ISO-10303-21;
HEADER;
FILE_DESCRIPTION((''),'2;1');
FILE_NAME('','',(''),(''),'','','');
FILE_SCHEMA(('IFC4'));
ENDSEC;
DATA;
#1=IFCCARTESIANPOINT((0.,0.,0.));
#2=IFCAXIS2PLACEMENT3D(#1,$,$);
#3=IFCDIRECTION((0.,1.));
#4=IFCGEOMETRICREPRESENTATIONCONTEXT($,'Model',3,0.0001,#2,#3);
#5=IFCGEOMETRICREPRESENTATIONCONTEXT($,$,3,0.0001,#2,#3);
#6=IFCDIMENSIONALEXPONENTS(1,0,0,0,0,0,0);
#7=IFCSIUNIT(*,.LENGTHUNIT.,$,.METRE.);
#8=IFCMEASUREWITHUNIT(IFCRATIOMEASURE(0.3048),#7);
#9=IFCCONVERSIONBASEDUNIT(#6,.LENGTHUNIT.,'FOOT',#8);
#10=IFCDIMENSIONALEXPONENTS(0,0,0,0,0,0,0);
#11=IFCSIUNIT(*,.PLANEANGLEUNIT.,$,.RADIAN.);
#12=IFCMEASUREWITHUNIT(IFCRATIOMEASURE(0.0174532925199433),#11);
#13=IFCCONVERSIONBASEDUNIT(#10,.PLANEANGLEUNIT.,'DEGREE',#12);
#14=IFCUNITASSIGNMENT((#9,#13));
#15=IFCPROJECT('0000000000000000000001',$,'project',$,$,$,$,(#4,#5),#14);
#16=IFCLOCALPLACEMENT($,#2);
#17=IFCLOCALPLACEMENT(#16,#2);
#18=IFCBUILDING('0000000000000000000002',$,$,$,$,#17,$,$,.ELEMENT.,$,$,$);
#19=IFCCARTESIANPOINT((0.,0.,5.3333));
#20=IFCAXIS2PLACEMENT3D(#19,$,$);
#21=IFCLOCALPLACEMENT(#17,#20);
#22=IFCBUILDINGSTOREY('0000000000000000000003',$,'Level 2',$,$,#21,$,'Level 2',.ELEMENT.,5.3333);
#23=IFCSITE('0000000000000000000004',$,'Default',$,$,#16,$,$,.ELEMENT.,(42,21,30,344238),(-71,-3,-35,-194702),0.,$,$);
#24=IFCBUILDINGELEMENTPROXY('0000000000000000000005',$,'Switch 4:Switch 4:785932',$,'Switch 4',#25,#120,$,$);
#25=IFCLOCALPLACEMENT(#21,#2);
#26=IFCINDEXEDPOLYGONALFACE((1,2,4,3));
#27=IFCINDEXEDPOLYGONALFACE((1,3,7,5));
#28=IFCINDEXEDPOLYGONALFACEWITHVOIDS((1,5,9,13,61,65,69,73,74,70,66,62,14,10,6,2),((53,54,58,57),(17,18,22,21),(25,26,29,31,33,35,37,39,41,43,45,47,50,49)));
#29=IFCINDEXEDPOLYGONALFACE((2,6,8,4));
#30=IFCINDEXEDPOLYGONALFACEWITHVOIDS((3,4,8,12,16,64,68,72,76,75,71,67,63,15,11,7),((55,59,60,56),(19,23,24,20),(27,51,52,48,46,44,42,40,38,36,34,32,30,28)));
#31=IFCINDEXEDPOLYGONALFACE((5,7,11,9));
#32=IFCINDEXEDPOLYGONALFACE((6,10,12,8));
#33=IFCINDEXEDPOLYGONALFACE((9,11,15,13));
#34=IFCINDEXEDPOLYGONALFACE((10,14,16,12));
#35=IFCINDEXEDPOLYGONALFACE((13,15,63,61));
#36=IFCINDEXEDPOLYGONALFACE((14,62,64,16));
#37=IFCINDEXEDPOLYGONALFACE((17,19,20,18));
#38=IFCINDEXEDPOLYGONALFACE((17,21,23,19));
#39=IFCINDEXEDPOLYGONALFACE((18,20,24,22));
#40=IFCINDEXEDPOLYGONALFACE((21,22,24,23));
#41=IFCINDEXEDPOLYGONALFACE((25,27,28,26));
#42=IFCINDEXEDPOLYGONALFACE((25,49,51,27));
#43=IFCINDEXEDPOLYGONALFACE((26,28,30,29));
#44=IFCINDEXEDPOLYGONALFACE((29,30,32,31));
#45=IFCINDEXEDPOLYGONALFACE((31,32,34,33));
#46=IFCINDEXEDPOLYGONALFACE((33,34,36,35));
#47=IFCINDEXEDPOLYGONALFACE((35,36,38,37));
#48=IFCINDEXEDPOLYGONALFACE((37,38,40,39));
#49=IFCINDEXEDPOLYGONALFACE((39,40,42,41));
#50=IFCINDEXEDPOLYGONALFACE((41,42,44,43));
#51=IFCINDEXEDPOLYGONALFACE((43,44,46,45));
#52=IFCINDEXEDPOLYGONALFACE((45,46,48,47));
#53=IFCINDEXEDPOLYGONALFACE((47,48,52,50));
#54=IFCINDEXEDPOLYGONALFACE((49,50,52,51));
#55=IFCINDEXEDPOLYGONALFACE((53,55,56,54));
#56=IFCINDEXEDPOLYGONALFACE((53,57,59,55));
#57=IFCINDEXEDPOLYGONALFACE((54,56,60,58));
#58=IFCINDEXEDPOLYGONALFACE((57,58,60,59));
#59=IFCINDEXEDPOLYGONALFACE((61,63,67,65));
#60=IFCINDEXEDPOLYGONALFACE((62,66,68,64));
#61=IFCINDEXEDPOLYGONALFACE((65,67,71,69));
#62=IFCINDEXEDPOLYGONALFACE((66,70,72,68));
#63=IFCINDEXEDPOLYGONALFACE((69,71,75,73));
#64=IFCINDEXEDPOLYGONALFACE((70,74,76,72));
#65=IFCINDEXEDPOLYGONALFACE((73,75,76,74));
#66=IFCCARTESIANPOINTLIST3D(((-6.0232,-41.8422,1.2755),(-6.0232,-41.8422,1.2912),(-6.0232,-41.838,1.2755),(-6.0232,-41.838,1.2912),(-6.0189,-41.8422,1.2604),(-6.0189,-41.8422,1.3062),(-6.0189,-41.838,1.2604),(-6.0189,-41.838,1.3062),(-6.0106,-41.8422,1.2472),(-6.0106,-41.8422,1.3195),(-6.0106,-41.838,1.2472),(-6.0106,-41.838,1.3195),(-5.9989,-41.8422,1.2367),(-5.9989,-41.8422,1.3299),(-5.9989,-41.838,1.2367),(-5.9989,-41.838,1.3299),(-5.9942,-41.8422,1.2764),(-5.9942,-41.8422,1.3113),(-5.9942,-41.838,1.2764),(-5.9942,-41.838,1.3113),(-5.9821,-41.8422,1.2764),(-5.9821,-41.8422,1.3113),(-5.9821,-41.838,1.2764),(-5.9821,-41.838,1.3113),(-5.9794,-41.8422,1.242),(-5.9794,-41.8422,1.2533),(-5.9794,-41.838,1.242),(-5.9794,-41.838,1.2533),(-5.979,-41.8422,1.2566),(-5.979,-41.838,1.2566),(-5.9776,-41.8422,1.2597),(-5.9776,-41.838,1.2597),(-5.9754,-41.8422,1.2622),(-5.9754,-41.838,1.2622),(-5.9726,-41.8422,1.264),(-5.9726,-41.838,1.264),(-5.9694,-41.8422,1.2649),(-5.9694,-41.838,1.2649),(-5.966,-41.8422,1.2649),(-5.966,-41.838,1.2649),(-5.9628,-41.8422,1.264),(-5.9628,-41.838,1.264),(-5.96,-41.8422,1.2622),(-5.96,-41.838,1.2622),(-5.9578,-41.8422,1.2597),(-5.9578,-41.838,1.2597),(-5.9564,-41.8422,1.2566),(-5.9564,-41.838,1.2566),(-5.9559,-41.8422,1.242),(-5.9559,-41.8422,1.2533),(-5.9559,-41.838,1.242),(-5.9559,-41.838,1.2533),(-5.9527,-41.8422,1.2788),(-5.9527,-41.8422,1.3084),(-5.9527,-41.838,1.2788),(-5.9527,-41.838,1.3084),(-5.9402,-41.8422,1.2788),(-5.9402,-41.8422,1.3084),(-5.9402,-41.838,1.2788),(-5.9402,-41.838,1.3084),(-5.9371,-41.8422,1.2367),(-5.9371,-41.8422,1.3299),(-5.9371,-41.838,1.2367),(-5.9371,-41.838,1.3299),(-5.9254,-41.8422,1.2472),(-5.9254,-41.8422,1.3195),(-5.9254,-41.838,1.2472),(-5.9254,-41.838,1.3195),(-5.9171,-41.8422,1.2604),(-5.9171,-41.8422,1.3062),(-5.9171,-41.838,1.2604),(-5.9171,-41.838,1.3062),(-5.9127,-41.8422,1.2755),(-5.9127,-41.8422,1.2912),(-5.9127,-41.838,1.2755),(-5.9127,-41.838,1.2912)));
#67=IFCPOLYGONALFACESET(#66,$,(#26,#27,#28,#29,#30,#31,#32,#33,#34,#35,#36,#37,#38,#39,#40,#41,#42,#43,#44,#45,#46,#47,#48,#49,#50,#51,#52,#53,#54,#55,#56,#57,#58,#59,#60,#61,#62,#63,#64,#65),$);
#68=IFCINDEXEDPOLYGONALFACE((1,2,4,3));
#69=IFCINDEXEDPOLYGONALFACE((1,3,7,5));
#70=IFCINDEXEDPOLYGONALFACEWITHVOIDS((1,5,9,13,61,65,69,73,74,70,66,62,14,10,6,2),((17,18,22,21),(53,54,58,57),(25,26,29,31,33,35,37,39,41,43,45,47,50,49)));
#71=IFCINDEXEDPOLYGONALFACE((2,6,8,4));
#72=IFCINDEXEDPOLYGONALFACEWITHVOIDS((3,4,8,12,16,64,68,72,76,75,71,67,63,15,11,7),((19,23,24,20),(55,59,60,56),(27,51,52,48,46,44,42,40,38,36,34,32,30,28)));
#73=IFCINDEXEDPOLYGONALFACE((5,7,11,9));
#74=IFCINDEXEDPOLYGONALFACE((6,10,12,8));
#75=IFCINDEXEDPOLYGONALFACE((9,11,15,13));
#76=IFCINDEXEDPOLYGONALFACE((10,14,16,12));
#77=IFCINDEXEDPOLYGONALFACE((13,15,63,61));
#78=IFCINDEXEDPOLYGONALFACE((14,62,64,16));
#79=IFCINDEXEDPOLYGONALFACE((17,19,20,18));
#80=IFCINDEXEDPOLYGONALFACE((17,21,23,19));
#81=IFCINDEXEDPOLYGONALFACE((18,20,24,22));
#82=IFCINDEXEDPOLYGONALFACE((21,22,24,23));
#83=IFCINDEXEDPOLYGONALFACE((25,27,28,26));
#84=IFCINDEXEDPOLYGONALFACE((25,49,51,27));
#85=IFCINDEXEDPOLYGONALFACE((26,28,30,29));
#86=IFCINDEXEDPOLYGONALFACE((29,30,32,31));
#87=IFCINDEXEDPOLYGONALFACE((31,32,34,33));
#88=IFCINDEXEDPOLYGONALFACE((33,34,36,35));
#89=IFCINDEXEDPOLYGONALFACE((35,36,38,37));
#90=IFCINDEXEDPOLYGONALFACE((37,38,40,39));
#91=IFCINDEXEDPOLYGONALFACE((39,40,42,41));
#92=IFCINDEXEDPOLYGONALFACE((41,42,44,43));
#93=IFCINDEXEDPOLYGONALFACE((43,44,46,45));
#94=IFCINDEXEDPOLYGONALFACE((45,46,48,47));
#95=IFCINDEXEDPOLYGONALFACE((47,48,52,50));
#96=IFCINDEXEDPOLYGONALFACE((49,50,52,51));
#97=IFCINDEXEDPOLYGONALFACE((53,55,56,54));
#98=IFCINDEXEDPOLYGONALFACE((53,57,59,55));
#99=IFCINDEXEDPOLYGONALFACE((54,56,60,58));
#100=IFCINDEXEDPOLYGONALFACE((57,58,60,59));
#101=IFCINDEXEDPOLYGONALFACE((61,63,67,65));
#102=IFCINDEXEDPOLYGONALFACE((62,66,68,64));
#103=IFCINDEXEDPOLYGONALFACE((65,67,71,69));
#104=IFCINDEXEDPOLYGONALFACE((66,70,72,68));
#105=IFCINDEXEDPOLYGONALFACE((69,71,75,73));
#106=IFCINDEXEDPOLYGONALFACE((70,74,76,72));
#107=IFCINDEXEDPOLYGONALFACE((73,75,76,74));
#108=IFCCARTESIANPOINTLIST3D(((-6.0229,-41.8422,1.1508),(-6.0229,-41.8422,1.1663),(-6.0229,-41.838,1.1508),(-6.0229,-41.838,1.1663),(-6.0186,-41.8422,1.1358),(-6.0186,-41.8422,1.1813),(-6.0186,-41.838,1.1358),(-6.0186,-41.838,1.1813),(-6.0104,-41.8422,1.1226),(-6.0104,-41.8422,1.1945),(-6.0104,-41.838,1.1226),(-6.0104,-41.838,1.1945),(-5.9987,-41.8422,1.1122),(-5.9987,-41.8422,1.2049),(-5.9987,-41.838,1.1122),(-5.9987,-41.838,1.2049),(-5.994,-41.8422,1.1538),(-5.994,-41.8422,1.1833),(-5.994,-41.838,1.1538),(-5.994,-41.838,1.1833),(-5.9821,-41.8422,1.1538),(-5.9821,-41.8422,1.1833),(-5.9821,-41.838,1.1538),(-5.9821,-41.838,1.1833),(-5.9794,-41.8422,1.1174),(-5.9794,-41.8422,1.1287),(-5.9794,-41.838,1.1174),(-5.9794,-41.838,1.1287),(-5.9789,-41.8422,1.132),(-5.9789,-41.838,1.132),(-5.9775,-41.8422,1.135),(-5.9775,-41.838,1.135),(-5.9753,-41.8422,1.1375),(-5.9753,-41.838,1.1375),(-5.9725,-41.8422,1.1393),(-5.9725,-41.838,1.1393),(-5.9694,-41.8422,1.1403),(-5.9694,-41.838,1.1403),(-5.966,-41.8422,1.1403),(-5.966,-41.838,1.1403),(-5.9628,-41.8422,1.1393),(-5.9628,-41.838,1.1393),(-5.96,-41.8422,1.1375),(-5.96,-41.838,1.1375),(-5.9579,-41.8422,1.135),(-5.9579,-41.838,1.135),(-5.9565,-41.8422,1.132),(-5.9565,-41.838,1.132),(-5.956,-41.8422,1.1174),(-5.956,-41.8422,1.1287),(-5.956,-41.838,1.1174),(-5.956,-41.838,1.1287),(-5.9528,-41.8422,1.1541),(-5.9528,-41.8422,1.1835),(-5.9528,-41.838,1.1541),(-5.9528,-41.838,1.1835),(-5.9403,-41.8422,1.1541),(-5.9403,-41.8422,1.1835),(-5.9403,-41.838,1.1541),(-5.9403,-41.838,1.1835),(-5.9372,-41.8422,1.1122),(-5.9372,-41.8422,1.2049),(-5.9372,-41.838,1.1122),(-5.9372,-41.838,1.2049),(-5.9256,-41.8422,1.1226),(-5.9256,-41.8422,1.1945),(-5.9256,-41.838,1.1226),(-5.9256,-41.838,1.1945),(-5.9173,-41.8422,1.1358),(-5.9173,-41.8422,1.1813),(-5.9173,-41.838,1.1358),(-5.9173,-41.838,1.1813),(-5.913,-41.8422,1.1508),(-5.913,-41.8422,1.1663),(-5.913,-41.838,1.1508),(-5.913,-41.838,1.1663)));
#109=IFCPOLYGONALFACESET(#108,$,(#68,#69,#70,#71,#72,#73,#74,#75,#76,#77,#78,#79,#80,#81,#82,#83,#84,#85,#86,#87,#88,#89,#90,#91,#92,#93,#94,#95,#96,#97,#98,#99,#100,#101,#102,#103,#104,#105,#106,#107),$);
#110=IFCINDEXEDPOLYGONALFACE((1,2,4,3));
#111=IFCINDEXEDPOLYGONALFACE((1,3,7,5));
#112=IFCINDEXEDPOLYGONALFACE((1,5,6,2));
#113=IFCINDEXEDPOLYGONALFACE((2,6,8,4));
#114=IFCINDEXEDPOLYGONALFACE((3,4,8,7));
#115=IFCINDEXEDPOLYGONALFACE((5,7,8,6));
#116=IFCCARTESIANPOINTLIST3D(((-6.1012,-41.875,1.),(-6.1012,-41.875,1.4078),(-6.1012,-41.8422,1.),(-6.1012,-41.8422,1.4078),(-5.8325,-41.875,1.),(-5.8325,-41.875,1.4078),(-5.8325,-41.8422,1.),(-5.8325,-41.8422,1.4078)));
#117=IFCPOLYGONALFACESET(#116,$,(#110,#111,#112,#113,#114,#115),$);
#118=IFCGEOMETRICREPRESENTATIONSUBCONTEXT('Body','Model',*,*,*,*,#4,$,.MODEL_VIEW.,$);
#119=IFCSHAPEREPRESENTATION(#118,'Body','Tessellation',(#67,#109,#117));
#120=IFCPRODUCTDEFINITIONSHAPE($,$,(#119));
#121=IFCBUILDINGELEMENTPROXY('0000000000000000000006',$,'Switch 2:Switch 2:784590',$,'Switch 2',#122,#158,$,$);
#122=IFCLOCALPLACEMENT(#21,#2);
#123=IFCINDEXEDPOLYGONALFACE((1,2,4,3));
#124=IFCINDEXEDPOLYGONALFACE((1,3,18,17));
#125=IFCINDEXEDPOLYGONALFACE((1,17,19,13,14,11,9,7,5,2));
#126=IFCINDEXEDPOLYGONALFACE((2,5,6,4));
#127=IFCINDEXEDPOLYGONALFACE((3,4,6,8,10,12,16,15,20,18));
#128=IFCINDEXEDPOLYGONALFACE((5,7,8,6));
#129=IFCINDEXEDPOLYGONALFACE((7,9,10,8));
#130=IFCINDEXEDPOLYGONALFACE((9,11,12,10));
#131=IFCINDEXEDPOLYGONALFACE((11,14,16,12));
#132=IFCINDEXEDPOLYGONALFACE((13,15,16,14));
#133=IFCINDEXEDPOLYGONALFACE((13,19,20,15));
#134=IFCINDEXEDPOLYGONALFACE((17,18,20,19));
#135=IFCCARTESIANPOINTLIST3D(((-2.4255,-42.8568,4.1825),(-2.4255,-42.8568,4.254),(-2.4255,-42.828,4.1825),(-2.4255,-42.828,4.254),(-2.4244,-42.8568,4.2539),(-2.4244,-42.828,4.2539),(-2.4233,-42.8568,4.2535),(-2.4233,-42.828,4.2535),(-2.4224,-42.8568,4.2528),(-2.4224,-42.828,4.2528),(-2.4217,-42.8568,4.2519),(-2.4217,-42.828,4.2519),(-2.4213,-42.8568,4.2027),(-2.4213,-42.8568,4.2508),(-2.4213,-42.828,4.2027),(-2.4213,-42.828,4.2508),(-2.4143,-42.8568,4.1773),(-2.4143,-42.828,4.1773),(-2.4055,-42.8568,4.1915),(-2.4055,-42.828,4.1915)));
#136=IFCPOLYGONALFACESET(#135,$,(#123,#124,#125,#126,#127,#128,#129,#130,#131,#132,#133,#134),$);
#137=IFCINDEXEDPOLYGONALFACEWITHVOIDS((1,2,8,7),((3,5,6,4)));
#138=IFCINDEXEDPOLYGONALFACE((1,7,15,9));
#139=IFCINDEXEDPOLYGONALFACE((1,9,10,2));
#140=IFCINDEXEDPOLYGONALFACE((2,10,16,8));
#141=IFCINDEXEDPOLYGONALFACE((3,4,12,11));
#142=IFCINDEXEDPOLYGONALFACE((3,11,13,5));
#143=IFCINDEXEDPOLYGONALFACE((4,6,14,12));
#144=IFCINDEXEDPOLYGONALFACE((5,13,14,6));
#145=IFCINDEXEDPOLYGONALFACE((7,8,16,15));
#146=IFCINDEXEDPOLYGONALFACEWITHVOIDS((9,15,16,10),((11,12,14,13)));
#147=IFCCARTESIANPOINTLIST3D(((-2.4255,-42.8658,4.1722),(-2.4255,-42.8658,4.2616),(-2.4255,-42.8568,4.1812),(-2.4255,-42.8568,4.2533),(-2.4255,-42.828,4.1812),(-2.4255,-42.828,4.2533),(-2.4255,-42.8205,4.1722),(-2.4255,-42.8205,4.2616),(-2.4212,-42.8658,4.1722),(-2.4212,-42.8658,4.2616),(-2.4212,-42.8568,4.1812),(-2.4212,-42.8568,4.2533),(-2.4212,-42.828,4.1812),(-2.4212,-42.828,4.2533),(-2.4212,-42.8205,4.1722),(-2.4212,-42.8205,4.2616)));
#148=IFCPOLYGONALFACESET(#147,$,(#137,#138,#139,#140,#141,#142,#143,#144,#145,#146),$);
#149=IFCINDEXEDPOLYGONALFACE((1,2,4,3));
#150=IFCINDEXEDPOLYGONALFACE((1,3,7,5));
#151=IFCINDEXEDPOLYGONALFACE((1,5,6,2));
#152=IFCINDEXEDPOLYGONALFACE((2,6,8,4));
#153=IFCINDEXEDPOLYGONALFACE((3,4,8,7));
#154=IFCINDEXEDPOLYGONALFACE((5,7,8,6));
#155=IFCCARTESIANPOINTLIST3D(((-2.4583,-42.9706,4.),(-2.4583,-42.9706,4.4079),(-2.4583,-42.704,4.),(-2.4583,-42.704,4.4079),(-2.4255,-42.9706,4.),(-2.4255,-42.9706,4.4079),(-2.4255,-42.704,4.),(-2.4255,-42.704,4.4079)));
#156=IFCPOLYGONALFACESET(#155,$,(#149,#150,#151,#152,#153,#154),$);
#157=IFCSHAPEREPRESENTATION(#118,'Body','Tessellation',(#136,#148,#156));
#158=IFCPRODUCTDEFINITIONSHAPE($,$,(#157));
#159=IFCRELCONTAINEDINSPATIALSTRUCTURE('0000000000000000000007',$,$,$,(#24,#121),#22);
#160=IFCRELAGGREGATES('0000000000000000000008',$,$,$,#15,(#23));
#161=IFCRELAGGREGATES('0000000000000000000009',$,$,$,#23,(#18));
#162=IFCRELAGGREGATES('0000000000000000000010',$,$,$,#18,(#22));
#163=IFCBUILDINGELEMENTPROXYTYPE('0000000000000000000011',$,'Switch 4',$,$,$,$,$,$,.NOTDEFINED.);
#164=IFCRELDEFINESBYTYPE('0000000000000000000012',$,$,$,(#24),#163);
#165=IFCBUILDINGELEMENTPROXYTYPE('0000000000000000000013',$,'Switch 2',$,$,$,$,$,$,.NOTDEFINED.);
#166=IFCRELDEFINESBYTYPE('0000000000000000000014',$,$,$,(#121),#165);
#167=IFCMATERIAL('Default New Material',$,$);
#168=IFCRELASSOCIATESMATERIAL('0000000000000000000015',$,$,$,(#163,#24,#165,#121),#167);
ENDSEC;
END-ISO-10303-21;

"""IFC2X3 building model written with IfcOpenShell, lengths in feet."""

from ifc_helpers import new_model, entity, si_unit, converted_unit, direction, frame, frame_2d, origin, origin_2d_with_axis, place, context, subcontext, project, spatial, polyline, circle_curve, parameter, trimmed, segment, composite_curve, rectangle, outline, extrude, source, transform, mapped, material, type_object, type_shapes, element, save


model = new_model("IFC2X3")

# Units and contexts
model_context = context("Model", 3, precision=0.0001, world=origin(), true_north=direction((0.0, 1.0)))
context_of_model = context(None, 3, precision=0.0001, world=origin(), true_north=direction((0.0, 1.0)))
body_context = subcontext(model_context, "Body", "Model", "MODEL_VIEW")
ifc_project = project(units=[converted_unit("LENGTHUNIT", "FOOT", entity("IfcRatioMeasure", 0.3048), si_unit("LENGTHUNIT", "METRE"), dimensions=[1, 0, 0, 0, 0, 0, 0]), converted_unit("PLANEANGLEUNIT", "DEGREE", entity("IfcRatioMeasure", 0.0174532925199433), si_unit("PLANEANGLEUNIT", "RADIAN"), dimensions=[0, 0, 0, 0, 0, 0, 0])], contexts=[model_context, context_of_model])

# Site, building, storey
site_placement = place(None, origin())
site = spatial("IfcSite", under=ifc_project, at=site_placement, Name="Default", CompositionType="ELEMENT", RefLatitude=(42, 21, 30, 344238), RefLongitude=(-71, -3, -35, -194702), RefElevation=0.0)
building_placement = place(site_placement, origin())
building = spatial("IfcBuilding", under=site, at=building_placement, CompositionType="ELEMENT")
storey_placement = place(building_placement, frame((0.0, 0.0, 5.3333)))
storey = spatial("IfcBuildingStorey", under=building, at=storey_placement, Name="Level 2", LongName="Level 2", CompositionType="ELEMENT", Elevation=5.3333)

# Shared definitions
ifc_material_1 = material(Name="Default New Material")

# Building element proxies
building_element_proxy_type_1 = type_object("IfcBuildingElementProxyType", Name="Switch 4", PredefinedType="NOTDEFINED", material=ifc_material_1)
shared_shape_1 = source(origin(), body_context, "Body", "SweptSolid", [
    extrude(outline(composite_curve([segment(polyline([(-0.0309, -0.0466), (0.0309, -0.0466)]), True, "CONTINUOUS"), segment(trimmed(circle_curve(frame_2d((-0.0003, 0.0), x_axis=(-1.0, 0.0)), 0.0561), [parameter(123.794741)], [parameter(236.205259)], True, "PARAMETER"), True, "CONTINUOUS"), segment(polyline([(0.0309, 0.0466), (-0.0309, 0.0466)]), True, "CONTINUOUS"), segment(trimmed(circle_curve(frame_2d((0.0003, 0.0), x_axis=(1.0, 0.0)), 0.0561), [parameter(123.794741)], [parameter(236.205259)], True, "PARAMETER"), True, "CONTINUOUS")], self_intersect=False), holes=[polyline([(0.0142, 0.0279), (0.0262, 0.0279), (0.0262, -0.0069), (0.0142, -0.0069), (0.0142, 0.0279)]), polyline([(-0.0153, 0.025), (-0.0153, -0.0045), (-0.0278, -0.0045), (-0.0278, 0.025), (-0.0153, 0.025)]), composite_curve([segment(polyline([(-0.012, -0.0413), (-0.012, -0.03)]), True, "CONTINUOUS"), segment(trimmed(circle_curve(frame_2d((-0.0003, -0.03), x_axis=(-1.0, 0.0)), 0.0117), [parameter(180.0)], [parameter(0.0)], True, "PARAMETER"), False, "CONTINUOUS"), segment(polyline([(0.0115, -0.03), (0.0115, -0.0413)]), True, "CONTINUOUS"), segment(polyline([(0.0115, -0.0413), (-0.012, -0.0413)]), True, "CONTINUOUS")], self_intersect=False)]), frame((-0.0011, 0.0328, 0.2833), z_axis=(0.0, 1.0, 0.0), x_axis=(-1.0, 0.0, 0.0)), (0.0, 0.0, 1.0), 0.0042),
    extrude(outline(composite_curve([segment(polyline([(-0.0308, -0.0464), (0.0308, -0.0464)]), True, "CONTINUOUS"), segment(trimmed(circle_curve(frame_2d((-0.0003, 0.0), x_axis=(-1.0, 0.0)), 0.0558), [parameter(123.794741)], [parameter(236.205259)], True, "PARAMETER"), True, "CONTINUOUS"), segment(polyline([(0.0308, 0.0464), (-0.0308, 0.0464)]), True, "CONTINUOUS"), segment(trimmed(circle_curve(frame_2d((0.0003, 0.0), x_axis=(1.0, 0.0)), 0.0558), [parameter(123.794741)], [parameter(236.205259)], True, "PARAMETER"), True, "CONTINUOUS")], self_intersect=False), holes=[polyline([(0.0141, 0.0247), (0.026, 0.0247), (0.026, -0.0047), (0.0141, -0.0047), (0.0141, 0.0247)]), polyline([(-0.0152, 0.0249), (-0.0152, -0.0045), (-0.0277, -0.0045), (-0.0277, 0.0249), (-0.0152, 0.0249)]), composite_curve([segment(polyline([(-0.012, -0.0411), (-0.012, -0.0299)]), True, "CONTINUOUS"), segment(trimmed(circle_curve(frame_2d((-0.0003, -0.0299), x_axis=(-1.0, 0.0)), 0.0117), [parameter(180.0)], [parameter(0.0)], True, "PARAMETER"), False, "CONTINUOUS"), segment(polyline([(0.0114, -0.0299), (0.0114, -0.0411)]), True, "CONTINUOUS"), segment(polyline([(0.0114, -0.0411), (-0.012, -0.0411)]), True, "CONTINUOUS")], self_intersect=False)]), frame((-0.0011, 0.0328, 0.1586), z_axis=(0.0, 1.0, 0.0), x_axis=(-1.0, 0.0, 0.0)), (0.0, 0.0, 1.0), 0.0042),
    extrude(rectangle(XDim=0.0328, YDim=0.2687, at=origin_2d_with_axis()), frame((0.0, 0.0164, 0.0), z_axis=(0.0, 0.0, 1.0), x_axis=(0.0, -1.0, 0.0)), (0.0, 0.0, 1.0), 0.4078),
])
type_shapes(building_element_proxy_type_1, [shared_shape_1])
proxy_placement = place(storey_placement, frame((-5.9669, -41.875, 1.0)))
element("IfcBuildingElementProxy", 1, at=proxy_placement, inside=storey, type_object=building_element_proxy_type_1, material=ifc_material_1, Name="Switch 4:Switch 4:785932", ObjectType="Switch 4", context=body_context, shape_type="MappedRepresentation", body=[
    mapped(shared_shape_1, transform((0.0, 0.0, 0.0), scale=1.0)),
])
building_element_proxy_type_2 = type_object("IfcBuildingElementProxyType", Name="Switch 2", PredefinedType="NOTDEFINED", material=ifc_material_1)
shared_shape_2 = source(origin(), body_context, "Body", "SweptSolid", [
    extrude(outline(composite_curve([segment(polyline([(-0.0252, -0.0211), (-0.0084, -0.0211)]), True, "CONTINUOUS"), segment(polyline([(-0.0084, -0.0211), (-0.0073, -0.0017)]), True, "CONTINUOUS"), segment(polyline([(-0.0073, -0.0017), (0.0336, 0.0237)]), True, "CONTINUOUS"), segment(trimmed(circle_curve(frame_2d((0.0308, 0.0266), x_axis=(0.848706, 0.528865)), 0.004), [parameter(281.689503)], [parameter(4.471238)], True, "PARAMETER"), True, "CONTINUOUS"), segment(polyline([(0.034, 0.029), (-0.0267, -0.0088)]), True, "CONTINUOUS"), segment(polyline([(-0.0267, -0.0088), (-0.0252, -0.0211)]), True, "CONTINUOUS")], self_intersect=False)), frame((-0.0093, 0.0394, 0.2098), z_axis=(1.0, 0.0, 0.0), x_axis=(0.0, 0.528865, 0.848706)), (0.0, 0.0, 1.0), 0.0287),
    extrude(outline(polyline([(-0.0447, -0.0227), (0.0447, -0.0227), (0.0447, 0.0227), (-0.0447, 0.0227), (-0.0447, -0.0227)]), holes=[polyline([(-0.0364, -0.0136), (-0.0364, 0.0151), (0.0357, 0.0151), (0.0357, -0.0136), (-0.0364, -0.0136)])]), frame((0.0058, 0.0329, 0.2169), z_axis=(0.0, 1.0, 0.0), x_axis=(0.0, 0.0, -1.0)), (0.0, 0.0, 1.0), 0.0042),
    extrude(rectangle(XDim=0.0329, YDim=0.2666, at=origin_2d_with_axis()), frame((-0.0001, 0.0164, 0.0), z_axis=(0.0, 0.0, 1.0), x_axis=(0.0, -1.0, 0.0)), (0.0, 0.0, 1.0), 0.4079),
])
type_shapes(building_element_proxy_type_2, [shared_shape_2])
for number, where, z_axis, x_axis, name in (
    (2, (-2.4583, -42.8373, 4.0), (0.0, 0.0, 1.0), (0.0, -1.0, 0.0), "Switch 2:Switch 2:784590"),
):
    element("IfcBuildingElementProxy", number, at=place(storey_placement, frame(where, z_axis=z_axis, x_axis=x_axis)), inside=storey, type_object=building_element_proxy_type_2, material=ifc_material_1, Name=name, ObjectType="Switch 2", context=body_context, shape_type="MappedRepresentation", body=[
        mapped(shared_shape_2, transform((0.0, 0.0, 0.0), scale=1.0)),
    ])

save(model, "model.ifc")
